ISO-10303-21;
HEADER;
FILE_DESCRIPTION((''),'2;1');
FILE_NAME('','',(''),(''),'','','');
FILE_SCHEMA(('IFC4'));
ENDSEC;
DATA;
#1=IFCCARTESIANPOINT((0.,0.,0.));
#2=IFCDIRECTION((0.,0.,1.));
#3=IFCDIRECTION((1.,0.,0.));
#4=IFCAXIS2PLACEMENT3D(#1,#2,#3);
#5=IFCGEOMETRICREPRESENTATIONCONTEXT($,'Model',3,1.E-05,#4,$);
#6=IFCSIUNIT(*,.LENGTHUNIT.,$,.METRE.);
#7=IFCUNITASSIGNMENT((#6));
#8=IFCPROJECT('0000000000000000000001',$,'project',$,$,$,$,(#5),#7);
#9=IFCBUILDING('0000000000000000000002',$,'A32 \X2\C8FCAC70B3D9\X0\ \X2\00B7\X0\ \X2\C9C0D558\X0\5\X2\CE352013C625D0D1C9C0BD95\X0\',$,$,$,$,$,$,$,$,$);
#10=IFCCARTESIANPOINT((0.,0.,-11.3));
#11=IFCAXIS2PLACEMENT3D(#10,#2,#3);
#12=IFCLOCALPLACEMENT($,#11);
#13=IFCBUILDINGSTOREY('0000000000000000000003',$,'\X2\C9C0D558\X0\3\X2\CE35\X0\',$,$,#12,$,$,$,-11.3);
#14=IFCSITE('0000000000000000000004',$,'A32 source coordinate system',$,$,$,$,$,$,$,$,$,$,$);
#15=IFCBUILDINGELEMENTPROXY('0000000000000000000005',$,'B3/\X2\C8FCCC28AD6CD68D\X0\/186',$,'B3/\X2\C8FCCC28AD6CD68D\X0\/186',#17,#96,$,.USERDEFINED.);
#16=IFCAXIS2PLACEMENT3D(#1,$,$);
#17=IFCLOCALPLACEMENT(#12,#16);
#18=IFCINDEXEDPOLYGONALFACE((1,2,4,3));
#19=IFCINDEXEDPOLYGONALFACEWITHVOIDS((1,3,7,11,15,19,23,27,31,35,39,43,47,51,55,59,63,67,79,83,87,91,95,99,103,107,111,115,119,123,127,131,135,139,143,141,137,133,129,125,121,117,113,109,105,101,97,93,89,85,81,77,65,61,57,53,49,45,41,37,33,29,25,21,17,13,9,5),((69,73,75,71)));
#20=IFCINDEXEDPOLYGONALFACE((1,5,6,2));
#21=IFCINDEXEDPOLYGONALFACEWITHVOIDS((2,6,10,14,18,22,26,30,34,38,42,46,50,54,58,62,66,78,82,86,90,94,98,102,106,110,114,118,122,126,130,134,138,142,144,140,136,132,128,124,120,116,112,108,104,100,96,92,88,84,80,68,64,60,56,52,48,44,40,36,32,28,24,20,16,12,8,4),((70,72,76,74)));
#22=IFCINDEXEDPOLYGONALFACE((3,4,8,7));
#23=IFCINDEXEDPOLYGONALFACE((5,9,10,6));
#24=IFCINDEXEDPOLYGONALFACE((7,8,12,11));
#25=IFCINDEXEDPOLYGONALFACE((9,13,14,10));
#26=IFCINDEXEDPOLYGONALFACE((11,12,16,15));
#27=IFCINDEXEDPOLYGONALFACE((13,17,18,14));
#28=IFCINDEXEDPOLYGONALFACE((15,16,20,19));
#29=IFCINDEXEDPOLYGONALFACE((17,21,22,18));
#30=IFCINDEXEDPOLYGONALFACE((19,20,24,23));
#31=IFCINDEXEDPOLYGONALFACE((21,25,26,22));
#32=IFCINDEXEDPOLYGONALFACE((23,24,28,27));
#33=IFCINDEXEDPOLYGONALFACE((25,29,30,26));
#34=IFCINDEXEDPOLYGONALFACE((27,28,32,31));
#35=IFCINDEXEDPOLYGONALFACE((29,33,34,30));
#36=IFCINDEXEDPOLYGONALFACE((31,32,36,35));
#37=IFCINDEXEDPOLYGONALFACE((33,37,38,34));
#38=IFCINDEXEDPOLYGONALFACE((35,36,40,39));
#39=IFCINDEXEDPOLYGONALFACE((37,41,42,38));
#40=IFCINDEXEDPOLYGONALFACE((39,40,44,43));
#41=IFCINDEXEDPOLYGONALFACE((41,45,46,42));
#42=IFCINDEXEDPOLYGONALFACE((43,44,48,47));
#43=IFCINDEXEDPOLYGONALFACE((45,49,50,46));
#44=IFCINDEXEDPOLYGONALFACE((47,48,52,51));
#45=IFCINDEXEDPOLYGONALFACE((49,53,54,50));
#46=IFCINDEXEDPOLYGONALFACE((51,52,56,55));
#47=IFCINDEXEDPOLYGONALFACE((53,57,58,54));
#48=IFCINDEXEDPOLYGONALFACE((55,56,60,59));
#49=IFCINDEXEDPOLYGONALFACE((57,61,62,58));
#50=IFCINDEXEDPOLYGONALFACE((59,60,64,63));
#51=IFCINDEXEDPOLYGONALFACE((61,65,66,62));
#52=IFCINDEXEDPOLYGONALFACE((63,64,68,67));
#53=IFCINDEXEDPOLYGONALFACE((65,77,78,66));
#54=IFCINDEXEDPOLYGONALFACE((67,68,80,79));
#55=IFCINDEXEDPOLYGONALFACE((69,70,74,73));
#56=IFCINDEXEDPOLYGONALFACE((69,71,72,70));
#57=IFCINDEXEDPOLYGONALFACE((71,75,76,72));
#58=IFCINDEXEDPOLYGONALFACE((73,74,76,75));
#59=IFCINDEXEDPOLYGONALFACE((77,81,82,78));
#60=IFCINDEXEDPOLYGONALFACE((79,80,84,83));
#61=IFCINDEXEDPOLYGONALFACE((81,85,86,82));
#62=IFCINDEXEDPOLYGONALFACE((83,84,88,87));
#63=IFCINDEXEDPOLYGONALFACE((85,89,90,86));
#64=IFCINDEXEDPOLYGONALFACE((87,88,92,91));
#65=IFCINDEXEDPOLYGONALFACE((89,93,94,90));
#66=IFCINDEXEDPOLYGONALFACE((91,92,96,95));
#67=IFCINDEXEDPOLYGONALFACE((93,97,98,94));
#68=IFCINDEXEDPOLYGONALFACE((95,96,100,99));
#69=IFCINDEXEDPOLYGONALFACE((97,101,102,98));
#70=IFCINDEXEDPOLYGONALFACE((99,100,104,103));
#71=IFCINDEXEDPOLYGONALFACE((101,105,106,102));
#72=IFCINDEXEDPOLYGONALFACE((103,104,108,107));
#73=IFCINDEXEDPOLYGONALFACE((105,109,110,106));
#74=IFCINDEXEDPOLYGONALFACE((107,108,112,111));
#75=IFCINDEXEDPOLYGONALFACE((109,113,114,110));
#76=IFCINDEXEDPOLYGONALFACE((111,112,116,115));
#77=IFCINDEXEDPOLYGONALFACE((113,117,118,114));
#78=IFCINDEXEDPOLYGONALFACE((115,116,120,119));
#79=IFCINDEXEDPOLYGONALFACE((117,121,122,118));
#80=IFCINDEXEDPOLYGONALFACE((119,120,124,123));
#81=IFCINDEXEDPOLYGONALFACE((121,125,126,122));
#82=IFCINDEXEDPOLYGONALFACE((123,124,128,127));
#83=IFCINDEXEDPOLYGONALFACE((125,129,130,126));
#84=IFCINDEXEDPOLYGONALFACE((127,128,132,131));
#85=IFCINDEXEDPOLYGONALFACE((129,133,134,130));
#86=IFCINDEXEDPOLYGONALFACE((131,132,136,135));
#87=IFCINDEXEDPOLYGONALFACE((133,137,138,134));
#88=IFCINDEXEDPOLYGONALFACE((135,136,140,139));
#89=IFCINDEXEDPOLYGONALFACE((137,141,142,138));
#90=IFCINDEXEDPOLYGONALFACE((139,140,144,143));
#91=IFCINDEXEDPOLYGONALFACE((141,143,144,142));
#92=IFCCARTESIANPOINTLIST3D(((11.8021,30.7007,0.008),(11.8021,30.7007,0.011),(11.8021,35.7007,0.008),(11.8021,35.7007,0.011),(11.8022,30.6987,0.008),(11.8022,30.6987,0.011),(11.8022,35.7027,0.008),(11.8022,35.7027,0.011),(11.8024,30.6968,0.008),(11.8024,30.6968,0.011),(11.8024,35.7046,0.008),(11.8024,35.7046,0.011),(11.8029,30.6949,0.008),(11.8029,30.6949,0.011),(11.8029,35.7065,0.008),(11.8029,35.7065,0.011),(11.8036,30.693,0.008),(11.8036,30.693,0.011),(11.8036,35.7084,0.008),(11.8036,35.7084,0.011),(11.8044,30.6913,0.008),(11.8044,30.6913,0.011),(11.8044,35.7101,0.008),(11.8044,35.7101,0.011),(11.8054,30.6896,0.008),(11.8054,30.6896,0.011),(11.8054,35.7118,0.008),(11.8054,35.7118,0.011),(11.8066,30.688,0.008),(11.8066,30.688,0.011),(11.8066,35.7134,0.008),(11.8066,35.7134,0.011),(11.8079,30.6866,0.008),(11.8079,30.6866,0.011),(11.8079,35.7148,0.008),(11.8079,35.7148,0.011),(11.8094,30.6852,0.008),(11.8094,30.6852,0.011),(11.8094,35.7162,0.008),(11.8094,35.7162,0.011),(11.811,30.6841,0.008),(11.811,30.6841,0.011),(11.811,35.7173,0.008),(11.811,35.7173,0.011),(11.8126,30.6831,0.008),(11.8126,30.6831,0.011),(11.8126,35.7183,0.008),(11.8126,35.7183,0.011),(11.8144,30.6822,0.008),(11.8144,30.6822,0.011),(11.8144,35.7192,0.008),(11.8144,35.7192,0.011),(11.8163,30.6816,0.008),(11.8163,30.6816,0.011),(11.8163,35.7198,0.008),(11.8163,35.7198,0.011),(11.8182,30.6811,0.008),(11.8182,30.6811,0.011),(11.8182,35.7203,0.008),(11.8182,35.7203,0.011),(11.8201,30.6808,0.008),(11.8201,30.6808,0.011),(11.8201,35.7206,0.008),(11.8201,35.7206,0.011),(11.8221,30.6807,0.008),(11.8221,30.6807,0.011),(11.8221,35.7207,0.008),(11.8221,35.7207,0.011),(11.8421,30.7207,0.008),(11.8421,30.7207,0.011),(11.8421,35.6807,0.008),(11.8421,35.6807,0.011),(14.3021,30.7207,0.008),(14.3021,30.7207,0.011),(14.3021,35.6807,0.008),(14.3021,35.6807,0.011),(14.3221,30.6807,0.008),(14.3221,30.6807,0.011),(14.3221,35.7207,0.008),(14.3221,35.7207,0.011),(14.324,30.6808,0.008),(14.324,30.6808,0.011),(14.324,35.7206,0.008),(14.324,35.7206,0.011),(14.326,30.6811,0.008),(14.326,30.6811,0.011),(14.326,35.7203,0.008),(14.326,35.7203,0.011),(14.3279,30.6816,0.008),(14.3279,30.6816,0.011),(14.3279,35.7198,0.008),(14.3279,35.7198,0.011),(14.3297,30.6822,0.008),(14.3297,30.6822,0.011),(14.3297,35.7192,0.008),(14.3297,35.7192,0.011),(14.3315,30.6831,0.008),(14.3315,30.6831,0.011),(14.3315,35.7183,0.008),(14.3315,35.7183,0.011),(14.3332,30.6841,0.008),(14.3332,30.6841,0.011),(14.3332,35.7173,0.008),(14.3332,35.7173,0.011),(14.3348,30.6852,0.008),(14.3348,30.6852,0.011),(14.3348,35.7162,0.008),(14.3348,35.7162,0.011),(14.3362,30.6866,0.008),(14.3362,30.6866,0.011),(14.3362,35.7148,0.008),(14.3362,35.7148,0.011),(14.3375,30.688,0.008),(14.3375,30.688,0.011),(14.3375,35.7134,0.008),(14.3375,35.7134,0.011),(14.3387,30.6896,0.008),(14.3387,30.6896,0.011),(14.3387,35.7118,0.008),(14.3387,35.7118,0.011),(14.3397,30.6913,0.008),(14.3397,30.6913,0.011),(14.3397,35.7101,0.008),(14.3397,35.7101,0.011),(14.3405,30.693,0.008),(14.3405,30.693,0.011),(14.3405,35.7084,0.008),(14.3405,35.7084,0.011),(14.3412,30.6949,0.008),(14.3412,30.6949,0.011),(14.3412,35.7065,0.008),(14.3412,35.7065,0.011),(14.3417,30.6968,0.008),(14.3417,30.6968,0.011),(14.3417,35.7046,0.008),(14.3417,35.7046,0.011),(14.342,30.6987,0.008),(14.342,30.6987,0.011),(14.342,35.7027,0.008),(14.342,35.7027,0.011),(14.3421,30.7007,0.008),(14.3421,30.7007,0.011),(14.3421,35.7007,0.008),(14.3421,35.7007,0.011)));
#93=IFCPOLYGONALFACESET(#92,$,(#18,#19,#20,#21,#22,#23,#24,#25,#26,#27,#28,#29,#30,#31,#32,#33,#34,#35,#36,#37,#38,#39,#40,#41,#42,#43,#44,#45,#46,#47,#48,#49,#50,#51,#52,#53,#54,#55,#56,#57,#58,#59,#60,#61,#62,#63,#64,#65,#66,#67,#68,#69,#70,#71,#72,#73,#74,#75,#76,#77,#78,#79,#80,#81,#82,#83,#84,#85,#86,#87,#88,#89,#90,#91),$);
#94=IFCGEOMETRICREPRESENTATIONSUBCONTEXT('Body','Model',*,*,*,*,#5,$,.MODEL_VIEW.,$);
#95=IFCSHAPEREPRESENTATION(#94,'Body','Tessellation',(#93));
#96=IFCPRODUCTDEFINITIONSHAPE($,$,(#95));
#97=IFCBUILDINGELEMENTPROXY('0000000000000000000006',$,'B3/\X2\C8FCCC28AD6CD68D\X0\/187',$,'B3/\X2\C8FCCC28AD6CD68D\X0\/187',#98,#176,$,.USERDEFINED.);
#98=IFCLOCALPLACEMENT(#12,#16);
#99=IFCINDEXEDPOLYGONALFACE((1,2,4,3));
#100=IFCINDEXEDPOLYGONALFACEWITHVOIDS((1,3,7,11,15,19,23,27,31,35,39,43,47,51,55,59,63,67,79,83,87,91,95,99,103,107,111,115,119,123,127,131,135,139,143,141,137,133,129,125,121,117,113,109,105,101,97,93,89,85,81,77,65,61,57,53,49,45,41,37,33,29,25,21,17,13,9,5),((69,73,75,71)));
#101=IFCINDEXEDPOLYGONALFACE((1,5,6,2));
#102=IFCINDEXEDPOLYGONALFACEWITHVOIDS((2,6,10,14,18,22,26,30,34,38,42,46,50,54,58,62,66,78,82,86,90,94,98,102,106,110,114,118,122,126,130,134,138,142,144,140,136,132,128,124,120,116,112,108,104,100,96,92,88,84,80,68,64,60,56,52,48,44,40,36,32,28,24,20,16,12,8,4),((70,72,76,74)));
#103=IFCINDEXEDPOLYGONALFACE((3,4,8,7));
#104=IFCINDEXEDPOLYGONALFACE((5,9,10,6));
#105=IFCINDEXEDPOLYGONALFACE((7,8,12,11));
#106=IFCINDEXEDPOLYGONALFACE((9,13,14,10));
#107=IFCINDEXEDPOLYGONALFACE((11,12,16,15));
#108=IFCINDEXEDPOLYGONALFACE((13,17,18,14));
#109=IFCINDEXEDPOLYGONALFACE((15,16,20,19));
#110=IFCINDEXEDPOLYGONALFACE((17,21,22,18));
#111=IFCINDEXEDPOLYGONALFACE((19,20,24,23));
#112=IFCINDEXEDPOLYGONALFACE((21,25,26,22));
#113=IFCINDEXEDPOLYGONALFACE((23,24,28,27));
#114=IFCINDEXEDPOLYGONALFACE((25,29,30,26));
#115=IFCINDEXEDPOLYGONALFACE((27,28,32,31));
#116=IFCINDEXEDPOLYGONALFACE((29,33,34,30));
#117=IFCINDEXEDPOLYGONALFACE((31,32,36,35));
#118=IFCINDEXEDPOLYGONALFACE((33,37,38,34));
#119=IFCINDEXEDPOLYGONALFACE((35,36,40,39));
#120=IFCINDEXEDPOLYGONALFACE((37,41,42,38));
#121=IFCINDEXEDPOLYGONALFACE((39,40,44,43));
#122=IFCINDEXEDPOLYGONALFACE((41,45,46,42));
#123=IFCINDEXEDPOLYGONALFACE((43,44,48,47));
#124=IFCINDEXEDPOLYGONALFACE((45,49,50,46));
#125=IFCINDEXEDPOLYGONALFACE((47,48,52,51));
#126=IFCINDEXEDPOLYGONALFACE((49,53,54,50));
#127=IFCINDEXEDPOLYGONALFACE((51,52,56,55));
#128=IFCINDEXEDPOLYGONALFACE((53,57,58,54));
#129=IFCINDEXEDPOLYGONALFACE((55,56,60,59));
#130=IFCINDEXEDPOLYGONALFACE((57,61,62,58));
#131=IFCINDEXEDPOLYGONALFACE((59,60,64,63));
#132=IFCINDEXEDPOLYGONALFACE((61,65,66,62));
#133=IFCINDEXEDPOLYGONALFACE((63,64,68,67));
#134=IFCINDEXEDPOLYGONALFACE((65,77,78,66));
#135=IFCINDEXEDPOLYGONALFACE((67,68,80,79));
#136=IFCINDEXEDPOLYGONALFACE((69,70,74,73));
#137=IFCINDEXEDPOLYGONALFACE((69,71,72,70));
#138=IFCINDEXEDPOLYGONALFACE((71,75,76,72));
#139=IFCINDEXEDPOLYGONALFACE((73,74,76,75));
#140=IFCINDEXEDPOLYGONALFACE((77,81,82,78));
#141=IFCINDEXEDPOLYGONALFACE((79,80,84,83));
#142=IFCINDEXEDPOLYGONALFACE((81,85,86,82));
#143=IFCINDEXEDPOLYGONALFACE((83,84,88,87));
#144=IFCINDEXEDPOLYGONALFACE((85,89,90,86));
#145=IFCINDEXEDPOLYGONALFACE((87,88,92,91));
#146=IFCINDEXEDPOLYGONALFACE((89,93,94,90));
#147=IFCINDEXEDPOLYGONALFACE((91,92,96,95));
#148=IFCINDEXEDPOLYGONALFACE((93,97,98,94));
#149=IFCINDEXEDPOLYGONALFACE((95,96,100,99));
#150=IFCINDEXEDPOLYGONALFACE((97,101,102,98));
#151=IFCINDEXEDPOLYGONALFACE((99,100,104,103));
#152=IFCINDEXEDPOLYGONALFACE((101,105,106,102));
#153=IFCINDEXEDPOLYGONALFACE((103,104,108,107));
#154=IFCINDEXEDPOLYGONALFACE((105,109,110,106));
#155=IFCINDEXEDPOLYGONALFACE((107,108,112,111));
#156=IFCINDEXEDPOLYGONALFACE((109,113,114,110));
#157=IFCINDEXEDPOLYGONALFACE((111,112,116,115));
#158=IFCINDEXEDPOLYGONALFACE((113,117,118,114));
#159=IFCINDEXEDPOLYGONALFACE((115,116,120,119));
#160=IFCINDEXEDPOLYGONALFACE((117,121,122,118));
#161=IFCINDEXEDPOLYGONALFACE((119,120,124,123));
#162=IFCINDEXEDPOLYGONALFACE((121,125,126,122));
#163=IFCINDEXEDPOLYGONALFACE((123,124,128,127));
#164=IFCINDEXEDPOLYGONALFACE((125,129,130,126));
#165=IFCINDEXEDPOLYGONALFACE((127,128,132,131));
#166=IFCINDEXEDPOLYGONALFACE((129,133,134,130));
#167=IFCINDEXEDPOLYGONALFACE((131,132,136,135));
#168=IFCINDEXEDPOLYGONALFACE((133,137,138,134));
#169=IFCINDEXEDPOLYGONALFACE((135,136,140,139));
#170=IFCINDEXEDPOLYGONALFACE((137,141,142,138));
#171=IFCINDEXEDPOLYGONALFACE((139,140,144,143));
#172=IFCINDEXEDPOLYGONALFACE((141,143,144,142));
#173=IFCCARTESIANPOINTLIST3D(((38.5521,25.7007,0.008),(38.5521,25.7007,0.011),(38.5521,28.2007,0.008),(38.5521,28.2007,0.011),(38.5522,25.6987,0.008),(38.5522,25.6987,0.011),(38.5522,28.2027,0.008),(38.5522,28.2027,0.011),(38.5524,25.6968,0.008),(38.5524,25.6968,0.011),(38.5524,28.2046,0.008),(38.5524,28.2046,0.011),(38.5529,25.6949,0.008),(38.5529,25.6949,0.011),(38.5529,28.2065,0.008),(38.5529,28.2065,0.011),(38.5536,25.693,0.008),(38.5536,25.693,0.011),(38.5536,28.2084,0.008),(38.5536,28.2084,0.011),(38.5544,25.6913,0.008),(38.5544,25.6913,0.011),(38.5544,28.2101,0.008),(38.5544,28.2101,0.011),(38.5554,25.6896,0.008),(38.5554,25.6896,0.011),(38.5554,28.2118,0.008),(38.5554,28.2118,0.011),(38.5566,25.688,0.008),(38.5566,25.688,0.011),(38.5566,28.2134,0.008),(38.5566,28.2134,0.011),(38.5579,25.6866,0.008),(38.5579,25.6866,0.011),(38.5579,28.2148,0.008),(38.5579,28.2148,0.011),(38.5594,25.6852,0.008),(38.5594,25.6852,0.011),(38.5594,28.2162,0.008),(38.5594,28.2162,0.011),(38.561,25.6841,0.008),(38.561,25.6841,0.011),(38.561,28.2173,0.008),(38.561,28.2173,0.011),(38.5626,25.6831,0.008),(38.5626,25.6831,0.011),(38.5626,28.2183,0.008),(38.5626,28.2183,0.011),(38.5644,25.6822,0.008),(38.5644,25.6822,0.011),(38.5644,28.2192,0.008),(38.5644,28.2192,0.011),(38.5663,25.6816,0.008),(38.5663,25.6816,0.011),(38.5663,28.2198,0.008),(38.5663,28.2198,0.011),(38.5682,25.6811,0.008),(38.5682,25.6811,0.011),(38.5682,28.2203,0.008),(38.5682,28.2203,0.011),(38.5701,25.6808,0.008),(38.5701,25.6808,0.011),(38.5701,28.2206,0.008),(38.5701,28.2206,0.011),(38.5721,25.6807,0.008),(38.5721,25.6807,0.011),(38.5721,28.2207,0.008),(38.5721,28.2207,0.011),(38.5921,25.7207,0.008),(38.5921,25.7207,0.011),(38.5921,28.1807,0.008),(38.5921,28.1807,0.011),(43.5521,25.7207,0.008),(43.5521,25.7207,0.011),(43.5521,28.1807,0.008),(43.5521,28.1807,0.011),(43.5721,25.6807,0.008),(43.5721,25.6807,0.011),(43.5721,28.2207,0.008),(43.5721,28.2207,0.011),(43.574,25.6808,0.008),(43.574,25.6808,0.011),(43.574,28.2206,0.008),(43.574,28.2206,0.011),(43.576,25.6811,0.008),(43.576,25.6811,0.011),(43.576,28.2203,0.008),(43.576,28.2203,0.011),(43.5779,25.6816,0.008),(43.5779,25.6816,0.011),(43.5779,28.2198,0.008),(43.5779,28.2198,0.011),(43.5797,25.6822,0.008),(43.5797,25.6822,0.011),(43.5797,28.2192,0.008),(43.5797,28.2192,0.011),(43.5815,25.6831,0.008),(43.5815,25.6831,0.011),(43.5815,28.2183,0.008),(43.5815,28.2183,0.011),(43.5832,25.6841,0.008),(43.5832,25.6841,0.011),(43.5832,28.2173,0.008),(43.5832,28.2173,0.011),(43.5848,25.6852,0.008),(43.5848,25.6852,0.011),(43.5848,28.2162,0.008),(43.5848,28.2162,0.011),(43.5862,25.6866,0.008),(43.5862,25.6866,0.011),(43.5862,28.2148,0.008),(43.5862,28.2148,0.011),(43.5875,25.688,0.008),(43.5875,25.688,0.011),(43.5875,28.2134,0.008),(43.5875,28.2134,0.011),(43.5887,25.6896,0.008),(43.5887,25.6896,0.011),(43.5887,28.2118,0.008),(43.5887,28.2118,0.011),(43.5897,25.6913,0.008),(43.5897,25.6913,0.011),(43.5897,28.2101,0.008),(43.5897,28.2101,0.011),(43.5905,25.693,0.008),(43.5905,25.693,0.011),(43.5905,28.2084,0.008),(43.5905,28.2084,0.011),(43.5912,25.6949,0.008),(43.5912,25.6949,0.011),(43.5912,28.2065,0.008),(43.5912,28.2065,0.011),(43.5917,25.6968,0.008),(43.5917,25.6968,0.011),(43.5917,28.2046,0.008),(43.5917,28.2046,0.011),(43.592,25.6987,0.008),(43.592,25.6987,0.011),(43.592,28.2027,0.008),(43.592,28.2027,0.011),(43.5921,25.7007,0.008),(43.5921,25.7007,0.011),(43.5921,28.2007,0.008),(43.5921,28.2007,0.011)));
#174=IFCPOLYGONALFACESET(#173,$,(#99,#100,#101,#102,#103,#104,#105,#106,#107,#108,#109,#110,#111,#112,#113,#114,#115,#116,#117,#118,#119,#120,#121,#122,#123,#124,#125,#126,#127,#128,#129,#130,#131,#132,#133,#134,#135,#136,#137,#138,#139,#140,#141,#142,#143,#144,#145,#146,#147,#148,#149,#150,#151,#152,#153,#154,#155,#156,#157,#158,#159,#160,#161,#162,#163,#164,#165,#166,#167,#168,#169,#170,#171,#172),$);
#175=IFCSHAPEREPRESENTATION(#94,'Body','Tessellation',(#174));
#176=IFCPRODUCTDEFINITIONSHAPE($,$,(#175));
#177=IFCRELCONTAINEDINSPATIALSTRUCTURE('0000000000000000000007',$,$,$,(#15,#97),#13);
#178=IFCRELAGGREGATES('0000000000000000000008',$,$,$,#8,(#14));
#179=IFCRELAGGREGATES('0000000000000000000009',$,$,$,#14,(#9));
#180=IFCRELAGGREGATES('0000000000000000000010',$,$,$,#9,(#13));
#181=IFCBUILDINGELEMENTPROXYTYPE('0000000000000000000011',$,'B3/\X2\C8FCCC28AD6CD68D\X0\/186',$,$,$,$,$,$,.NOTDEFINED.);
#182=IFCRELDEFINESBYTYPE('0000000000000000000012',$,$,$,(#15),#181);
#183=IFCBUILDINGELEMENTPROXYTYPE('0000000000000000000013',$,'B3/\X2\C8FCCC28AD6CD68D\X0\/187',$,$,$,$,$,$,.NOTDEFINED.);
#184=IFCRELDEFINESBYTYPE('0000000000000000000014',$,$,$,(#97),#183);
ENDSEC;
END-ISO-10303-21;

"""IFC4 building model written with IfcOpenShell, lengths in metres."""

from ifc_helpers import new_model, si_unit, frame, origin, origin_with_axes, place, context, subcontext, project, spatial, polyline, outline, extrude, source, transform, mapped, type_object, type_shapes, element, save


model = new_model("IFC4")

# Units and contexts
model_context = context("Model", 3, precision=1e-05, world=origin_with_axes())
body_context = subcontext(model_context, "Body", "Model", "MODEL_VIEW")
ifc_project = project(units=[si_unit("LENGTHUNIT", "METRE")], contexts=[model_context])

# Site, building, storey
site = spatial("IfcSite", under=ifc_project, Name="A32 source coordinate system")
building = spatial("IfcBuilding", under=site, Name="A32 주거동 · 지하5층–옥탑지붕")
storey_placement = place(None, frame((0.0, 0.0, -11.3), z_axis=(0.0, 0.0, 1.0), x_axis=(1.0, 0.0, 0.0)))
storey = spatial("IfcBuildingStorey", under=building, at=storey_placement, Name="지하3층", Elevation=-11.3)

# Building element proxies
building_element_proxy_type_1 = type_object("IfcBuildingElementProxyType", Name="B3/주차구획/186", PredefinedType="NOTDEFINED")
shared_shape_1 = source(origin(), body_context, "Body", "SweptSolid", [
    extrude(outline(polyline([(11.8021, 35.7007), (11.8022, 35.7027), (11.8024, 35.7046), (11.8029, 35.7065), (11.8036, 35.7084), (11.8044, 35.7101), (11.8054, 35.7118), (11.8066, 35.7134), (11.8079, 35.7148), (11.8094, 35.7162), (11.811, 35.7173), (11.8126, 35.7183), (11.8144, 35.7192), (11.8163, 35.7198), (11.8182, 35.7203), (11.8201, 35.7206), (11.8221, 35.7207), (14.3221, 35.7207), (14.324, 35.7206), (14.326, 35.7203), (14.3279, 35.7198), (14.3297, 35.7192), (14.3315, 35.7183), (14.3332, 35.7173), (14.3348, 35.7162), (14.3362, 35.7148), (14.3375, 35.7134), (14.3387, 35.7118), (14.3397, 35.7101), (14.3405, 35.7084), (14.3412, 35.7065), (14.3417, 35.7046), (14.342, 35.7027), (14.3421, 35.7007), (14.3421, 30.7007), (14.342, 30.6987), (14.3417, 30.6968), (14.3412, 30.6949), (14.3405, 30.693), (14.3397, 30.6913), (14.3387, 30.6896), (14.3375, 30.688), (14.3362, 30.6866), (14.3348, 30.6852), (14.3332, 30.6841), (14.3315, 30.6831), (14.3297, 30.6822), (14.3279, 30.6816), (14.326, 30.6811), (14.324, 30.6808), (14.3221, 30.6807), (11.8221, 30.6807), (11.8201, 30.6808), (11.8182, 30.6811), (11.8163, 30.6816), (11.8144, 30.6822), (11.8126, 30.6831), (11.811, 30.6841), (11.8094, 30.6852), (11.8079, 30.6866), (11.8066, 30.688), (11.8054, 30.6896), (11.8044, 30.6913), (11.8036, 30.693), (11.8029, 30.6949), (11.8024, 30.6968), (11.8022, 30.6987), (11.8021, 30.7007), (11.8021, 35.7007)]), holes=[polyline([(11.8421, 35.6807), (11.8421, 30.7207), (14.3021, 30.7207), (14.3021, 35.6807), (11.8421, 35.6807)])]), frame((0.0, 0.0, 0.008)), (0.0, 0.0, 1.0), 0.003),
])
type_shapes(building_element_proxy_type_1, [shared_shape_1])
proxy_1_placement = place(storey_placement, origin_with_axes())
element("IfcBuildingElementProxy", 1, at=proxy_1_placement, inside=storey, type_object=building_element_proxy_type_1, Name="B3/주차구획/186", ObjectType="B3/주차구획/186", PredefinedType="USERDEFINED", context=body_context, shape_type="MappedRepresentation", body=[
    mapped(shared_shape_1, transform((0.0, 0.0, 0.0), scale=1.0)),
])
building_element_proxy_type_2 = type_object("IfcBuildingElementProxyType", Name="B3/주차구획/187", PredefinedType="NOTDEFINED")
shared_shape_2 = source(origin(), body_context, "Body", "SweptSolid", [
    extrude(outline(polyline([(43.5721, 28.2207), (43.574, 28.2206), (43.576, 28.2203), (43.5779, 28.2198), (43.5797, 28.2192), (43.5815, 28.2183), (43.5832, 28.2173), (43.5848, 28.2162), (43.5862, 28.2148), (43.5875, 28.2134), (43.5887, 28.2118), (43.5897, 28.2101), (43.5905, 28.2084), (43.5912, 28.2065), (43.5917, 28.2046), (43.592, 28.2027), (43.5921, 28.2007), (43.5921, 25.7007), (43.592, 25.6987), (43.5917, 25.6968), (43.5912, 25.6949), (43.5905, 25.693), (43.5897, 25.6913), (43.5887, 25.6896), (43.5875, 25.688), (43.5862, 25.6866), (43.5848, 25.6852), (43.5832, 25.6841), (43.5815, 25.6831), (43.5797, 25.6822), (43.5779, 25.6816), (43.576, 25.6811), (43.574, 25.6808), (43.5721, 25.6807), (38.5721, 25.6807), (38.5701, 25.6808), (38.5682, 25.6811), (38.5663, 25.6816), (38.5644, 25.6822), (38.5626, 25.6831), (38.561, 25.6841), (38.5594, 25.6852), (38.5579, 25.6866), (38.5566, 25.688), (38.5554, 25.6896), (38.5544, 25.6913), (38.5536, 25.693), (38.5529, 25.6949), (38.5524, 25.6968), (38.5522, 25.6987), (38.5521, 25.7007), (38.5521, 28.2007), (38.5522, 28.2027), (38.5524, 28.2046), (38.5529, 28.2065), (38.5536, 28.2084), (38.5544, 28.2101), (38.5554, 28.2118), (38.5566, 28.2134), (38.5579, 28.2148), (38.5594, 28.2162), (38.561, 28.2173), (38.5626, 28.2183), (38.5644, 28.2192), (38.5663, 28.2198), (38.5682, 28.2203), (38.5701, 28.2206), (38.5721, 28.2207), (43.5721, 28.2207)]), holes=[polyline([(43.5521, 28.1807), (38.5921, 28.1807), (38.5921, 25.7207), (43.5521, 25.7207), (43.5521, 28.1807)])]), frame((0.0, 0.0, 0.008)), (0.0, 0.0, 1.0), 0.003),
])
type_shapes(building_element_proxy_type_2, [shared_shape_2])
proxy_2_placement = place(storey_placement, origin_with_axes())
element("IfcBuildingElementProxy", 2, at=proxy_2_placement, inside=storey, type_object=building_element_proxy_type_2, Name="B3/주차구획/187", ObjectType="B3/주차구획/187", PredefinedType="USERDEFINED", context=body_context, shape_type="MappedRepresentation", body=[
    mapped(shared_shape_2, transform((0.0, 0.0, 0.0), scale=1.0)),
])

save(model, "model.ifc")
